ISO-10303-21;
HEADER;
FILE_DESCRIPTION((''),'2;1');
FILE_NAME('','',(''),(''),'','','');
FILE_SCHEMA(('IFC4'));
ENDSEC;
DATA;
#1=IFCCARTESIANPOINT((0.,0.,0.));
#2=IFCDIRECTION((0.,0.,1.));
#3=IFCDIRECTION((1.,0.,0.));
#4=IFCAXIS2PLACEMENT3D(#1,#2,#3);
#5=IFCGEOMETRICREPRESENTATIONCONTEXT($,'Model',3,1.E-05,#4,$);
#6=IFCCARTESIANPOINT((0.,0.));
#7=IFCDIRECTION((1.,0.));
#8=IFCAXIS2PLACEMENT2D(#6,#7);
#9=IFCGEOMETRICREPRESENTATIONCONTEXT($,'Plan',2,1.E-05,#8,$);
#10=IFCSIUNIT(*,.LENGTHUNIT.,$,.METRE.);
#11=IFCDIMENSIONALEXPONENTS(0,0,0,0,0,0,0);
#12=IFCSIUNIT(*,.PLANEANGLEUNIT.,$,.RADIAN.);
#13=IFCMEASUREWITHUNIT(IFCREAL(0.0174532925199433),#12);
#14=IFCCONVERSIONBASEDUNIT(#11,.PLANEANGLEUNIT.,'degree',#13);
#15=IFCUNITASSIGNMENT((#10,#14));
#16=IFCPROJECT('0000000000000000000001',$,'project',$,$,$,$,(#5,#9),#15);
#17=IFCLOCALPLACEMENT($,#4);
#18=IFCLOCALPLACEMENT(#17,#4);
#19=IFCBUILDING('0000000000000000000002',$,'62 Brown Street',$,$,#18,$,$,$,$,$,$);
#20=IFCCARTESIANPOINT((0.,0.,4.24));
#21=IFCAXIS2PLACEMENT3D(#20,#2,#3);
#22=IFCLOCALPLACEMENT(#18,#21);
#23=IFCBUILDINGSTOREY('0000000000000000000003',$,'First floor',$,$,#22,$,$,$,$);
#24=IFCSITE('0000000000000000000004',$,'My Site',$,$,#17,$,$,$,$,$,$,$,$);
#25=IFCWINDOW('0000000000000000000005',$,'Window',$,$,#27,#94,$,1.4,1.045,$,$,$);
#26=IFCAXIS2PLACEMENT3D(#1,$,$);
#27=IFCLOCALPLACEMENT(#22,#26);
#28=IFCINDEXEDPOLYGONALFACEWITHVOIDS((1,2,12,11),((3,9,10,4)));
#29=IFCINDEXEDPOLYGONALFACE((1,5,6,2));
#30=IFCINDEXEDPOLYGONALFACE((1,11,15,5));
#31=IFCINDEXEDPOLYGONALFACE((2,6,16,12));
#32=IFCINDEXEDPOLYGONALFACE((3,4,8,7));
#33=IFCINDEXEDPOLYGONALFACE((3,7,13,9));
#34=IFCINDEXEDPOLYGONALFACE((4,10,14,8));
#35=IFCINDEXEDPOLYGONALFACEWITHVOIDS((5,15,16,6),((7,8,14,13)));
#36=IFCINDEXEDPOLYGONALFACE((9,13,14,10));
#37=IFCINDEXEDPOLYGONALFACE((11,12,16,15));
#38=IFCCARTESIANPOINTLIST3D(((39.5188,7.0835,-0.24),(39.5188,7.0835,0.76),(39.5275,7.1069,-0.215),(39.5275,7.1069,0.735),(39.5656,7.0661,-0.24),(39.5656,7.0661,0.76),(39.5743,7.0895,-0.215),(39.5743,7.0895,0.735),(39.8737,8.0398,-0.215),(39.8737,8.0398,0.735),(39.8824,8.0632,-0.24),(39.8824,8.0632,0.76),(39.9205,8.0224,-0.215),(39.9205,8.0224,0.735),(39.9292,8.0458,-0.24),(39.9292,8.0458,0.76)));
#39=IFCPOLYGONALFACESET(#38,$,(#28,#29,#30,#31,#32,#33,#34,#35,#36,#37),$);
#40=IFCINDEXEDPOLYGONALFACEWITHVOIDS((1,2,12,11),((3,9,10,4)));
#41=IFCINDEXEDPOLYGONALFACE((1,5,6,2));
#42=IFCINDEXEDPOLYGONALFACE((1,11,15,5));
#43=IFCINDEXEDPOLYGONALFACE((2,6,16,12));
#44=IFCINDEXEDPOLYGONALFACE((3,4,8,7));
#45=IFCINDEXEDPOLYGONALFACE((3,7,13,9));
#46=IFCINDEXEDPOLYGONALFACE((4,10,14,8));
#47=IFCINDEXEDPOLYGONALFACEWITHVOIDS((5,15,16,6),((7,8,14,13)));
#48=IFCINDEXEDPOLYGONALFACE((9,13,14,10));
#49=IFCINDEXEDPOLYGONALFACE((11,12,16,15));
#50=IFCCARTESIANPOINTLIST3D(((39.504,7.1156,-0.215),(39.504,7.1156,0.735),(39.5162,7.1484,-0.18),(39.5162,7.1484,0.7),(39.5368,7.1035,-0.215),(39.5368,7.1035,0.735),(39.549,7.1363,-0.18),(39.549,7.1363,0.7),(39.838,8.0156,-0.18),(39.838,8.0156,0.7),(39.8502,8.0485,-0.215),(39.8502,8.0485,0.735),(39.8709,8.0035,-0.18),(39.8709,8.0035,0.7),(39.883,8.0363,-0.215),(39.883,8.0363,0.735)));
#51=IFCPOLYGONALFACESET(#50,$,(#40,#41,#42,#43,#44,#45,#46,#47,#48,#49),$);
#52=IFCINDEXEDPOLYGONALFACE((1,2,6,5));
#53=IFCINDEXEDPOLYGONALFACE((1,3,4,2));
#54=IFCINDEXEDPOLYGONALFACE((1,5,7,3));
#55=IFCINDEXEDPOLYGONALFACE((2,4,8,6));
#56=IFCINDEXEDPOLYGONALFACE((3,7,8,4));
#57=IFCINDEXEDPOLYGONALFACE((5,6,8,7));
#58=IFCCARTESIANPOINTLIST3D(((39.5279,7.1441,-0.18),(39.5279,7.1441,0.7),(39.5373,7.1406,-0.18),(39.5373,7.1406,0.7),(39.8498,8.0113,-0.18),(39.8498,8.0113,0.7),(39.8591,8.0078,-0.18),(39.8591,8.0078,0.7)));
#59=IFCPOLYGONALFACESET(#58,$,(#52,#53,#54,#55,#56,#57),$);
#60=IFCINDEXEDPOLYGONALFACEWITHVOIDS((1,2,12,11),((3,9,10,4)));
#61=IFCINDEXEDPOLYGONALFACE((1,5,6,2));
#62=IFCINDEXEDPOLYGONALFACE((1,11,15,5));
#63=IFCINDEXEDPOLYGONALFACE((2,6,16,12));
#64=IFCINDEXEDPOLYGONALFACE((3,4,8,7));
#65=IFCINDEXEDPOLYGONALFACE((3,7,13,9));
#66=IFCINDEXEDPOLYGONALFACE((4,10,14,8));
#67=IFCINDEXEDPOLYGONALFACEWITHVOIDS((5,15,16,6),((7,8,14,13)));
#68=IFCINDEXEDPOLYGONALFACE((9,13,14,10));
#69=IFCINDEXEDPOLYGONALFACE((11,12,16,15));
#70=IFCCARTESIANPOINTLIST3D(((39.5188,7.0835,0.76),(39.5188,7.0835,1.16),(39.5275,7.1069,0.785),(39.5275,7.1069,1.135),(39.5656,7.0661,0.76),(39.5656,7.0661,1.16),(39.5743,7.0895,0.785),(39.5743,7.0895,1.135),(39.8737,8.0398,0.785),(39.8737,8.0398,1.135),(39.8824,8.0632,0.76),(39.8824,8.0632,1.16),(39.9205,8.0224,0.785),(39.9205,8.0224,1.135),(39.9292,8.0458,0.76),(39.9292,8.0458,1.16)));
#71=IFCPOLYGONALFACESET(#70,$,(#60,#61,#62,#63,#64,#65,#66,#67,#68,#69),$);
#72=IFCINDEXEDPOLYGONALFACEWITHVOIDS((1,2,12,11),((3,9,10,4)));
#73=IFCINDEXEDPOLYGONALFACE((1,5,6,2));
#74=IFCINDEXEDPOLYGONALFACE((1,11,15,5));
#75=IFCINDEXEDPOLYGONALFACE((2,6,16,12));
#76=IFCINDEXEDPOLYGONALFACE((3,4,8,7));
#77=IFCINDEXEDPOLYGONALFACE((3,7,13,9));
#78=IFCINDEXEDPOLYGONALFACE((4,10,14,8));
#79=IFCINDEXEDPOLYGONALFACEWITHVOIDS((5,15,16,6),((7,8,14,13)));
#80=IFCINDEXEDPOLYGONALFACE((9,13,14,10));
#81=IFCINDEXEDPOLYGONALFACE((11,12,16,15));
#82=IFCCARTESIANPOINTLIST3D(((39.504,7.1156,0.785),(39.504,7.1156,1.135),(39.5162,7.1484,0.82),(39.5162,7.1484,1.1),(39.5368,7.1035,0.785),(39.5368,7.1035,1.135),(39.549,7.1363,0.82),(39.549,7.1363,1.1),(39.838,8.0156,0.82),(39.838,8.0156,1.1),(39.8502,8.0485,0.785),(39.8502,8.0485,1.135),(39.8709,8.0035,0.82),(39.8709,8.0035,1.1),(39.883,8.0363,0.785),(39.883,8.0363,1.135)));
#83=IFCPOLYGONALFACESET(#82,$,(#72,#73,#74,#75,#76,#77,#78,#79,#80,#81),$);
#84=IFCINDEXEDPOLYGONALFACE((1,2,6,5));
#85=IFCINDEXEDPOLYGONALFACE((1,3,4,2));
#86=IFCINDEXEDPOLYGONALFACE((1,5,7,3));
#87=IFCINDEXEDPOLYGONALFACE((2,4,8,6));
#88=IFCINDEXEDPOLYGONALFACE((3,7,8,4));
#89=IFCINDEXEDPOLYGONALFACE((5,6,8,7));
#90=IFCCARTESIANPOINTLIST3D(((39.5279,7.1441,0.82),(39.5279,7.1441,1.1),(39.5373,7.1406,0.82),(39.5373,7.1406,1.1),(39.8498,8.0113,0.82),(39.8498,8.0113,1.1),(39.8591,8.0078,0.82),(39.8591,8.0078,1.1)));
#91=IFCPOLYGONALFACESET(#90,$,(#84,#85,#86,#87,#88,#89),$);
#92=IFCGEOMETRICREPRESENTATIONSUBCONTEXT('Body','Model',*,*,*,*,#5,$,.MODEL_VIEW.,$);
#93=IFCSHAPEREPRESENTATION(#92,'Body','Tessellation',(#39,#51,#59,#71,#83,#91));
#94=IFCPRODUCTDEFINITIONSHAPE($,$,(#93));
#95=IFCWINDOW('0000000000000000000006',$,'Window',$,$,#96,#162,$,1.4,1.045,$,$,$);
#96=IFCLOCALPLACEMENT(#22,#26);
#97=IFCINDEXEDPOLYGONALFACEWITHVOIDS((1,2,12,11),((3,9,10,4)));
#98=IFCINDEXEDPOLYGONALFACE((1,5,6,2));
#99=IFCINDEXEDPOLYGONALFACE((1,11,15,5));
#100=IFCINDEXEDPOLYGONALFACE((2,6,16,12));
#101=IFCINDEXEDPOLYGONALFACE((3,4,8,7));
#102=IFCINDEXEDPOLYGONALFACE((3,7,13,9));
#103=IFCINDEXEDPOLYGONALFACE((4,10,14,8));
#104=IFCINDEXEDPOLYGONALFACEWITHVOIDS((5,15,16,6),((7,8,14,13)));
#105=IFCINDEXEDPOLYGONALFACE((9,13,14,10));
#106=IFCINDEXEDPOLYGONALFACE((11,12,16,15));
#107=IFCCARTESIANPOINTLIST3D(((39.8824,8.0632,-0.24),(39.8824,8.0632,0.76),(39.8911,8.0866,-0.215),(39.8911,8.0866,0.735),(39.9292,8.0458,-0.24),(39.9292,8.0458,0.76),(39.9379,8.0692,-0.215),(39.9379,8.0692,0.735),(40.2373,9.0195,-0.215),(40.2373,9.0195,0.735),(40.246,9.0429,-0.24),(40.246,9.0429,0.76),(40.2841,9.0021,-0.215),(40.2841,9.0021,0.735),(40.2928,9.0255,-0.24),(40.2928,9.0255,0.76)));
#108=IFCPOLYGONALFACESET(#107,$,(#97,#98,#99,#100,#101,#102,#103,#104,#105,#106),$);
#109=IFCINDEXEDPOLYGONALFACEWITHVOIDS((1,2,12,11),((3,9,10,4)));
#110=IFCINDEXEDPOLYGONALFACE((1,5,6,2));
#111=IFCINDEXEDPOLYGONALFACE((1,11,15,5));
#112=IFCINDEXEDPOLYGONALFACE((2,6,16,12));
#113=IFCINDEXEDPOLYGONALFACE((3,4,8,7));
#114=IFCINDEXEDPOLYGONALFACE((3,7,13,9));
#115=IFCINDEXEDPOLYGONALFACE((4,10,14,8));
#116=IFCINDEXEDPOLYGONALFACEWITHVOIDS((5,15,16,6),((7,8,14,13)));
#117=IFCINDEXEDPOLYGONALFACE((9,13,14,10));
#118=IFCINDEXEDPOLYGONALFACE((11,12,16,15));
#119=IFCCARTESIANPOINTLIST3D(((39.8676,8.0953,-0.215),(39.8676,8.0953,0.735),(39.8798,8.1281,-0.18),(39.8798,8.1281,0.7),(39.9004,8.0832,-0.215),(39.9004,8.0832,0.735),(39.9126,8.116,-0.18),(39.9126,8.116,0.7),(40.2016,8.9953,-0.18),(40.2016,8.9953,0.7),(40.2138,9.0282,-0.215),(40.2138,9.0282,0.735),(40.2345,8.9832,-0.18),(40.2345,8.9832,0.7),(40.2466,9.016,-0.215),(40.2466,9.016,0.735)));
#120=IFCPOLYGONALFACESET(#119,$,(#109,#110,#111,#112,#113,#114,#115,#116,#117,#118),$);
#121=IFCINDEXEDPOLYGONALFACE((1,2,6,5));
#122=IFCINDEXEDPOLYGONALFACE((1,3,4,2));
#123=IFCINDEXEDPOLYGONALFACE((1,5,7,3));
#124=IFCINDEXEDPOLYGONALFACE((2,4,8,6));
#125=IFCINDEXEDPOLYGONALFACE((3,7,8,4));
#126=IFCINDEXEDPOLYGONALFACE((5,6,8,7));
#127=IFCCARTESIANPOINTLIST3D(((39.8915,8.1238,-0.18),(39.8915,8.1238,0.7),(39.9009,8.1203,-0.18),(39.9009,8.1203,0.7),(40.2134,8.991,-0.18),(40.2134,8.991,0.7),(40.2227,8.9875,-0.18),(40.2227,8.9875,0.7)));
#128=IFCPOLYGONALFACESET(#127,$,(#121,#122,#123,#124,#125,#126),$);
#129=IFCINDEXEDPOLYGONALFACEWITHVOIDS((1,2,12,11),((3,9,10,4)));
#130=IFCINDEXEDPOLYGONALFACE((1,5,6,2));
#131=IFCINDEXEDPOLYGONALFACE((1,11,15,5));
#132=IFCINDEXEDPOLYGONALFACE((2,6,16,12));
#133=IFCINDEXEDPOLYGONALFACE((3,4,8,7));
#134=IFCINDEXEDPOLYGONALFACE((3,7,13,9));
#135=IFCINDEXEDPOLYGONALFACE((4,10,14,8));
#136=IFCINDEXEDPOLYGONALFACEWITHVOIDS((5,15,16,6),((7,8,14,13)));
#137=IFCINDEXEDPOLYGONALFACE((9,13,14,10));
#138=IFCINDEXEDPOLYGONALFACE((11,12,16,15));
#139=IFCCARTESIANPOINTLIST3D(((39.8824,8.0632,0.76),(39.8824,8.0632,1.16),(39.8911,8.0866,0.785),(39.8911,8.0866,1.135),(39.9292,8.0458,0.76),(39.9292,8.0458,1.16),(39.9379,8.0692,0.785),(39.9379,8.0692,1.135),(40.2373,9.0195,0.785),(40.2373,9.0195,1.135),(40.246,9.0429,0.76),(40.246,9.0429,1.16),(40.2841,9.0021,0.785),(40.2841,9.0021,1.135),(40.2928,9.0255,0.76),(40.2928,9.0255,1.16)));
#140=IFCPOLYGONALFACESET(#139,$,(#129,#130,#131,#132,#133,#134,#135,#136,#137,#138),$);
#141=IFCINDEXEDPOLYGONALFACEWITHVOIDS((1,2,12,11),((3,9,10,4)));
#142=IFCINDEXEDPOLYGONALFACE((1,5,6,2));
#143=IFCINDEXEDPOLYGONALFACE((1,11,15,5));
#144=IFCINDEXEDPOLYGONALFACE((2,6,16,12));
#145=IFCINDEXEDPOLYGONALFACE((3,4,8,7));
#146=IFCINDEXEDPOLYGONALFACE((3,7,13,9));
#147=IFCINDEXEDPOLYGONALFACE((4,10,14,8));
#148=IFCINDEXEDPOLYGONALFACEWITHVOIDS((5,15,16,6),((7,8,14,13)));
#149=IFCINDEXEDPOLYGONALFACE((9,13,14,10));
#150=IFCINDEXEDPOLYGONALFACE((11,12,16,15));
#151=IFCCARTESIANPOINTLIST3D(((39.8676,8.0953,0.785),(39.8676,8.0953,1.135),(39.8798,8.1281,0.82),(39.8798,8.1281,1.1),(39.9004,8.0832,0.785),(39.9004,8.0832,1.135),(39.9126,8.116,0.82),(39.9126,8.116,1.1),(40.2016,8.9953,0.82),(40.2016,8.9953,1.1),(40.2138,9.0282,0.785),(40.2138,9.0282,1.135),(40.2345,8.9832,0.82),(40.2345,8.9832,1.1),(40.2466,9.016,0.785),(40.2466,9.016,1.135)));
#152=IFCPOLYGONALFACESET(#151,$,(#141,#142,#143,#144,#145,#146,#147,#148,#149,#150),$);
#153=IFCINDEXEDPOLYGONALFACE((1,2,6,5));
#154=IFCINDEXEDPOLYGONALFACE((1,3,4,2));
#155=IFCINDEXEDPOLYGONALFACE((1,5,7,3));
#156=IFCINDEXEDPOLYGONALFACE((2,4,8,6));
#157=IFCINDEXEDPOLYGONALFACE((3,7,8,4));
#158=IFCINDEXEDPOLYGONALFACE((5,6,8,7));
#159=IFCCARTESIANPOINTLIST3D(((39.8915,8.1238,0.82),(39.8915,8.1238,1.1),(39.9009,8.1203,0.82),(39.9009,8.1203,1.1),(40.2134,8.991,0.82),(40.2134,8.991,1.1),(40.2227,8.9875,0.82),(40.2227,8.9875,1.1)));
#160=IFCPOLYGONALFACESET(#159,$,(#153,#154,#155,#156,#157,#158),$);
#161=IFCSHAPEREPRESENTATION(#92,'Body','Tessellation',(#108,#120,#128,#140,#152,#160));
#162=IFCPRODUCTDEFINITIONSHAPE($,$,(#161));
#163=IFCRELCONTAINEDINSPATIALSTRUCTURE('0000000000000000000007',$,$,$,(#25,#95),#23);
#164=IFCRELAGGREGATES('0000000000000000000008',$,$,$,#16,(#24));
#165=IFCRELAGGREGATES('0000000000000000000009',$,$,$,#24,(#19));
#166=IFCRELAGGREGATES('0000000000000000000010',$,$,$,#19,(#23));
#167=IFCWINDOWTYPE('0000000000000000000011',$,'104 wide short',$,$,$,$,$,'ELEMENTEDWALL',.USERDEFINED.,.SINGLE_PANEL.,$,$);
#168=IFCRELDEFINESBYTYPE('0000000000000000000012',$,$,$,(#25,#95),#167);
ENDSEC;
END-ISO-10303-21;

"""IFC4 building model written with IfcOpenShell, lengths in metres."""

from ifc_helpers import new_model, entity, si_unit, converted_unit, frame, origin_with_axes, origin_2d_with_axis, place, context, subcontext, project, spatial, line, indexed_curve, outline, extrude, shape, source, transform, mapped, type_object, type_shapes, element, save


model = new_model("IFC4")

# Units and contexts
model_context = context("Model", 3, precision=1e-05, world=origin_with_axes())
plan_context = context("Plan", 2, precision=1e-05, world=origin_2d_with_axis())
body_context_1 = subcontext(model_context, "Body", "Model", "MODEL_VIEW")
body_context_2 = subcontext(plan_context, "Body", "Plan", "PLAN_VIEW")
ifc_project = project(units=[si_unit("LENGTHUNIT", "METRE"), converted_unit("PLANEANGLEUNIT", "degree", entity("IfcReal", 0.0174532925199433), si_unit("PLANEANGLEUNIT", "RADIAN"), dimensions=[0, 0, 0, 0, 0, 0, 0])], contexts=[model_context, plan_context])

# Site, building, storey
site_placement = place(None, origin_with_axes())
site = spatial("IfcSite", under=ifc_project, at=site_placement, Name="My Site")
building_placement = place(site_placement, origin_with_axes())
building = spatial("IfcBuilding", under=site, at=building_placement, Name="62 Brown Street")
storey_placement = place(building_placement, frame((0.0, 0.0, 4.24), z_axis=(0.0, 0.0, 1.0), x_axis=(1.0, 0.0, 0.0)))
storey = spatial("IfcBuildingStorey", under=building, at=storey_placement, Name="First floor")

# Shared definitions
window_type_1 = type_object("IfcWindowType", Name="104 wide short", ElementType="ELEMENTEDWALL", PartitioningType="SINGLE_PANEL", PredefinedType="USERDEFINED")
shared_shape_1 = source(origin_with_axes(), body_context_1, "Body", "SweptSolid", [
    extrude(outline(indexed_curve([(0.0, 0.0), (1.045, 0.0), (1.045, 1.0), (0.0, 1.0)], segments=[line(1, 2, 3, 4, 1)]), holes=[indexed_curve([(0.025, 0.025), (1.02, 0.025), (1.02, 0.975), (0.025, 0.975)], segments=[line(1, 2, 3, 4, 1)])]), frame((0.0, 0.15, 0.0), z_axis=(0.0, -1.0, 0.0), x_axis=(1.0, 0.0, 0.0)), (0.0, 0.0, -1.0), 0.05),
    extrude(outline(indexed_curve([(0.0, 0.0), (0.995, 0.0), (0.995, 0.95), (0.0, 0.95)], segments=[line(1, 2, 3, 4, 1)]), holes=[indexed_curve([(0.035, 0.035), (0.96, 0.035), (0.96, 0.915), (0.035, 0.915)], segments=[line(1, 2, 3, 4, 1)])]), frame((0.025, 0.19, 0.025), z_axis=(0.0, -1.0, 0.0), x_axis=(1.0, 0.0, 0.0)), (0.0, 0.0, -1.0), 0.035),
    extrude(outline(indexed_curve([(0.035, 0.035), (0.96, 0.035), (0.96, 0.915), (0.035, 0.915)], segments=[line(1, 2, 3, 4, 1)])), frame((0.025, 0.2025, 0.025), z_axis=(0.0, -1.0, 0.0), x_axis=(1.0, 0.0, 0.0)), (0.0, 0.0, -1.0), 0.01),
    extrude(outline(indexed_curve([(0.0, 0.0), (1.045, 0.0), (1.045, 0.4), (0.0, 0.4)], segments=[line(1, 2, 3, 4, 1)]), holes=[indexed_curve([(0.025, 0.025), (1.02, 0.025), (1.02, 0.375), (0.025, 0.375)], segments=[line(1, 2, 3, 4, 1)])]), frame((0.0, 0.15, 1.0), z_axis=(0.0, -1.0, 0.0), x_axis=(1.0, 0.0, 0.0)), (0.0, 0.0, -1.0), 0.05),
    extrude(outline(indexed_curve([(0.0, 0.0), (0.995, 0.0), (0.995, 0.35), (0.0, 0.35)], segments=[line(1, 2, 3, 4, 1)]), holes=[indexed_curve([(0.035, 0.035), (0.96, 0.035), (0.96, 0.315), (0.035, 0.315)], segments=[line(1, 2, 3, 4, 1)])]), frame((0.025, 0.19, 1.025), z_axis=(0.0, -1.0, 0.0), x_axis=(1.0, 0.0, 0.0)), (0.0, 0.0, -1.0), 0.035),
    extrude(outline(indexed_curve([(0.035, 0.035), (0.96, 0.035), (0.96, 0.315), (0.035, 0.315)], segments=[line(1, 2, 3, 4, 1)])), frame((0.025, 0.2025, 1.025), z_axis=(0.0, -1.0, 0.0), x_axis=(1.0, 0.0, 0.0)), (0.0, 0.0, -1.0), 0.01),
])
shared_shape_2 = source(origin_with_axes(), body_context_2, "Body", "Curve2D", [
    entity("IfcIndexedPolyCurve", entity("IfcCartesianPointList2D", [[0.025, 0.15], [1.02, 0.15]])),
    entity("IfcIndexedPolyCurve", entity("IfcCartesianPointList2D", [[0.0, 0.2], [0.025, 0.2], [0.025, 0.15], [0.0, 0.15]]), [entity("IfcLineIndex", [1, 2, 3, 4, 1])]),
    entity("IfcIndexedPolyCurve", entity("IfcCartesianPointList2D", [[1.045, 0.2], [1.02, 0.2], [1.02, 0.15], [1.045, 0.15]]), [entity("IfcLineIndex", [1, 2, 3, 4, 1])]),
    entity("IfcIndexedPolyCurve", entity("IfcCartesianPointList2D", [[0.025, 0.19], [0.06, 0.19], [0.06, 0.225], [0.025, 0.225]]), [entity("IfcLineIndex", [1, 2, 3, 4, 1])]),
    entity("IfcIndexedPolyCurve", entity("IfcCartesianPointList2D", [[1.02, 0.19], [0.985, 0.19], [0.985, 0.225], [1.02, 0.225]]), [entity("IfcLineIndex", [1, 2, 3, 4, 1])]),
    entity("IfcIndexedPolyCurve", entity("IfcCartesianPointList2D", [[0.06, 0.19], [0.985, 0.19]])),
    entity("IfcIndexedPolyCurve", entity("IfcCartesianPointList2D", [[0.06, 0.225], [0.985, 0.225]])),
    entity("IfcIndexedPolyCurve", entity("IfcCartesianPointList2D", [[0.06, 0.2075], [0.985, 0.2075]])),
])
type_shapes(window_type_1, [shared_shape_1, shared_shape_2])

# Windows
for number, where, z_axis, x_axis, name in (
    (1, (39.7063, 7.0139, -0.24), (0.0, 0.0, 1.0), (0.347944, 0.937515, 0.0), "Window"),
    (2, (40.0699, 7.9936, -0.24), (0.0, 0.0, 1.0), (0.347944, 0.937515, 0.0), "Window"),
):
    element("IfcWindow", number, at=place(storey_placement, frame(where, z_axis=z_axis, x_axis=x_axis)), inside=storey, type_object=window_type_1, Name=name, OverallHeight=1.4, OverallWidth=1.045, shapes=[
        shape(body_context_1, "Body", "MappedRepresentation", [mapped(shared_shape_1, transform((0.0, 0.0, 0.0), x_axis=(1.0, 0.0, 0.0), y_axis=(0.0, 1.0, 0.0), z_axis=(0.0, 0.0, 1.0), scale=1.0))]),
        shape(body_context_2, "Body", "MappedRepresentation", [mapped(shared_shape_2, transform((0.0, 0.0, 0.0), x_axis=(1.0, 0.0, 0.0), y_axis=(0.0, 1.0, 0.0), z_axis=(0.0, 0.0, 1.0), scale=1.0))]),
    ])

save(model, "model.ifc")
